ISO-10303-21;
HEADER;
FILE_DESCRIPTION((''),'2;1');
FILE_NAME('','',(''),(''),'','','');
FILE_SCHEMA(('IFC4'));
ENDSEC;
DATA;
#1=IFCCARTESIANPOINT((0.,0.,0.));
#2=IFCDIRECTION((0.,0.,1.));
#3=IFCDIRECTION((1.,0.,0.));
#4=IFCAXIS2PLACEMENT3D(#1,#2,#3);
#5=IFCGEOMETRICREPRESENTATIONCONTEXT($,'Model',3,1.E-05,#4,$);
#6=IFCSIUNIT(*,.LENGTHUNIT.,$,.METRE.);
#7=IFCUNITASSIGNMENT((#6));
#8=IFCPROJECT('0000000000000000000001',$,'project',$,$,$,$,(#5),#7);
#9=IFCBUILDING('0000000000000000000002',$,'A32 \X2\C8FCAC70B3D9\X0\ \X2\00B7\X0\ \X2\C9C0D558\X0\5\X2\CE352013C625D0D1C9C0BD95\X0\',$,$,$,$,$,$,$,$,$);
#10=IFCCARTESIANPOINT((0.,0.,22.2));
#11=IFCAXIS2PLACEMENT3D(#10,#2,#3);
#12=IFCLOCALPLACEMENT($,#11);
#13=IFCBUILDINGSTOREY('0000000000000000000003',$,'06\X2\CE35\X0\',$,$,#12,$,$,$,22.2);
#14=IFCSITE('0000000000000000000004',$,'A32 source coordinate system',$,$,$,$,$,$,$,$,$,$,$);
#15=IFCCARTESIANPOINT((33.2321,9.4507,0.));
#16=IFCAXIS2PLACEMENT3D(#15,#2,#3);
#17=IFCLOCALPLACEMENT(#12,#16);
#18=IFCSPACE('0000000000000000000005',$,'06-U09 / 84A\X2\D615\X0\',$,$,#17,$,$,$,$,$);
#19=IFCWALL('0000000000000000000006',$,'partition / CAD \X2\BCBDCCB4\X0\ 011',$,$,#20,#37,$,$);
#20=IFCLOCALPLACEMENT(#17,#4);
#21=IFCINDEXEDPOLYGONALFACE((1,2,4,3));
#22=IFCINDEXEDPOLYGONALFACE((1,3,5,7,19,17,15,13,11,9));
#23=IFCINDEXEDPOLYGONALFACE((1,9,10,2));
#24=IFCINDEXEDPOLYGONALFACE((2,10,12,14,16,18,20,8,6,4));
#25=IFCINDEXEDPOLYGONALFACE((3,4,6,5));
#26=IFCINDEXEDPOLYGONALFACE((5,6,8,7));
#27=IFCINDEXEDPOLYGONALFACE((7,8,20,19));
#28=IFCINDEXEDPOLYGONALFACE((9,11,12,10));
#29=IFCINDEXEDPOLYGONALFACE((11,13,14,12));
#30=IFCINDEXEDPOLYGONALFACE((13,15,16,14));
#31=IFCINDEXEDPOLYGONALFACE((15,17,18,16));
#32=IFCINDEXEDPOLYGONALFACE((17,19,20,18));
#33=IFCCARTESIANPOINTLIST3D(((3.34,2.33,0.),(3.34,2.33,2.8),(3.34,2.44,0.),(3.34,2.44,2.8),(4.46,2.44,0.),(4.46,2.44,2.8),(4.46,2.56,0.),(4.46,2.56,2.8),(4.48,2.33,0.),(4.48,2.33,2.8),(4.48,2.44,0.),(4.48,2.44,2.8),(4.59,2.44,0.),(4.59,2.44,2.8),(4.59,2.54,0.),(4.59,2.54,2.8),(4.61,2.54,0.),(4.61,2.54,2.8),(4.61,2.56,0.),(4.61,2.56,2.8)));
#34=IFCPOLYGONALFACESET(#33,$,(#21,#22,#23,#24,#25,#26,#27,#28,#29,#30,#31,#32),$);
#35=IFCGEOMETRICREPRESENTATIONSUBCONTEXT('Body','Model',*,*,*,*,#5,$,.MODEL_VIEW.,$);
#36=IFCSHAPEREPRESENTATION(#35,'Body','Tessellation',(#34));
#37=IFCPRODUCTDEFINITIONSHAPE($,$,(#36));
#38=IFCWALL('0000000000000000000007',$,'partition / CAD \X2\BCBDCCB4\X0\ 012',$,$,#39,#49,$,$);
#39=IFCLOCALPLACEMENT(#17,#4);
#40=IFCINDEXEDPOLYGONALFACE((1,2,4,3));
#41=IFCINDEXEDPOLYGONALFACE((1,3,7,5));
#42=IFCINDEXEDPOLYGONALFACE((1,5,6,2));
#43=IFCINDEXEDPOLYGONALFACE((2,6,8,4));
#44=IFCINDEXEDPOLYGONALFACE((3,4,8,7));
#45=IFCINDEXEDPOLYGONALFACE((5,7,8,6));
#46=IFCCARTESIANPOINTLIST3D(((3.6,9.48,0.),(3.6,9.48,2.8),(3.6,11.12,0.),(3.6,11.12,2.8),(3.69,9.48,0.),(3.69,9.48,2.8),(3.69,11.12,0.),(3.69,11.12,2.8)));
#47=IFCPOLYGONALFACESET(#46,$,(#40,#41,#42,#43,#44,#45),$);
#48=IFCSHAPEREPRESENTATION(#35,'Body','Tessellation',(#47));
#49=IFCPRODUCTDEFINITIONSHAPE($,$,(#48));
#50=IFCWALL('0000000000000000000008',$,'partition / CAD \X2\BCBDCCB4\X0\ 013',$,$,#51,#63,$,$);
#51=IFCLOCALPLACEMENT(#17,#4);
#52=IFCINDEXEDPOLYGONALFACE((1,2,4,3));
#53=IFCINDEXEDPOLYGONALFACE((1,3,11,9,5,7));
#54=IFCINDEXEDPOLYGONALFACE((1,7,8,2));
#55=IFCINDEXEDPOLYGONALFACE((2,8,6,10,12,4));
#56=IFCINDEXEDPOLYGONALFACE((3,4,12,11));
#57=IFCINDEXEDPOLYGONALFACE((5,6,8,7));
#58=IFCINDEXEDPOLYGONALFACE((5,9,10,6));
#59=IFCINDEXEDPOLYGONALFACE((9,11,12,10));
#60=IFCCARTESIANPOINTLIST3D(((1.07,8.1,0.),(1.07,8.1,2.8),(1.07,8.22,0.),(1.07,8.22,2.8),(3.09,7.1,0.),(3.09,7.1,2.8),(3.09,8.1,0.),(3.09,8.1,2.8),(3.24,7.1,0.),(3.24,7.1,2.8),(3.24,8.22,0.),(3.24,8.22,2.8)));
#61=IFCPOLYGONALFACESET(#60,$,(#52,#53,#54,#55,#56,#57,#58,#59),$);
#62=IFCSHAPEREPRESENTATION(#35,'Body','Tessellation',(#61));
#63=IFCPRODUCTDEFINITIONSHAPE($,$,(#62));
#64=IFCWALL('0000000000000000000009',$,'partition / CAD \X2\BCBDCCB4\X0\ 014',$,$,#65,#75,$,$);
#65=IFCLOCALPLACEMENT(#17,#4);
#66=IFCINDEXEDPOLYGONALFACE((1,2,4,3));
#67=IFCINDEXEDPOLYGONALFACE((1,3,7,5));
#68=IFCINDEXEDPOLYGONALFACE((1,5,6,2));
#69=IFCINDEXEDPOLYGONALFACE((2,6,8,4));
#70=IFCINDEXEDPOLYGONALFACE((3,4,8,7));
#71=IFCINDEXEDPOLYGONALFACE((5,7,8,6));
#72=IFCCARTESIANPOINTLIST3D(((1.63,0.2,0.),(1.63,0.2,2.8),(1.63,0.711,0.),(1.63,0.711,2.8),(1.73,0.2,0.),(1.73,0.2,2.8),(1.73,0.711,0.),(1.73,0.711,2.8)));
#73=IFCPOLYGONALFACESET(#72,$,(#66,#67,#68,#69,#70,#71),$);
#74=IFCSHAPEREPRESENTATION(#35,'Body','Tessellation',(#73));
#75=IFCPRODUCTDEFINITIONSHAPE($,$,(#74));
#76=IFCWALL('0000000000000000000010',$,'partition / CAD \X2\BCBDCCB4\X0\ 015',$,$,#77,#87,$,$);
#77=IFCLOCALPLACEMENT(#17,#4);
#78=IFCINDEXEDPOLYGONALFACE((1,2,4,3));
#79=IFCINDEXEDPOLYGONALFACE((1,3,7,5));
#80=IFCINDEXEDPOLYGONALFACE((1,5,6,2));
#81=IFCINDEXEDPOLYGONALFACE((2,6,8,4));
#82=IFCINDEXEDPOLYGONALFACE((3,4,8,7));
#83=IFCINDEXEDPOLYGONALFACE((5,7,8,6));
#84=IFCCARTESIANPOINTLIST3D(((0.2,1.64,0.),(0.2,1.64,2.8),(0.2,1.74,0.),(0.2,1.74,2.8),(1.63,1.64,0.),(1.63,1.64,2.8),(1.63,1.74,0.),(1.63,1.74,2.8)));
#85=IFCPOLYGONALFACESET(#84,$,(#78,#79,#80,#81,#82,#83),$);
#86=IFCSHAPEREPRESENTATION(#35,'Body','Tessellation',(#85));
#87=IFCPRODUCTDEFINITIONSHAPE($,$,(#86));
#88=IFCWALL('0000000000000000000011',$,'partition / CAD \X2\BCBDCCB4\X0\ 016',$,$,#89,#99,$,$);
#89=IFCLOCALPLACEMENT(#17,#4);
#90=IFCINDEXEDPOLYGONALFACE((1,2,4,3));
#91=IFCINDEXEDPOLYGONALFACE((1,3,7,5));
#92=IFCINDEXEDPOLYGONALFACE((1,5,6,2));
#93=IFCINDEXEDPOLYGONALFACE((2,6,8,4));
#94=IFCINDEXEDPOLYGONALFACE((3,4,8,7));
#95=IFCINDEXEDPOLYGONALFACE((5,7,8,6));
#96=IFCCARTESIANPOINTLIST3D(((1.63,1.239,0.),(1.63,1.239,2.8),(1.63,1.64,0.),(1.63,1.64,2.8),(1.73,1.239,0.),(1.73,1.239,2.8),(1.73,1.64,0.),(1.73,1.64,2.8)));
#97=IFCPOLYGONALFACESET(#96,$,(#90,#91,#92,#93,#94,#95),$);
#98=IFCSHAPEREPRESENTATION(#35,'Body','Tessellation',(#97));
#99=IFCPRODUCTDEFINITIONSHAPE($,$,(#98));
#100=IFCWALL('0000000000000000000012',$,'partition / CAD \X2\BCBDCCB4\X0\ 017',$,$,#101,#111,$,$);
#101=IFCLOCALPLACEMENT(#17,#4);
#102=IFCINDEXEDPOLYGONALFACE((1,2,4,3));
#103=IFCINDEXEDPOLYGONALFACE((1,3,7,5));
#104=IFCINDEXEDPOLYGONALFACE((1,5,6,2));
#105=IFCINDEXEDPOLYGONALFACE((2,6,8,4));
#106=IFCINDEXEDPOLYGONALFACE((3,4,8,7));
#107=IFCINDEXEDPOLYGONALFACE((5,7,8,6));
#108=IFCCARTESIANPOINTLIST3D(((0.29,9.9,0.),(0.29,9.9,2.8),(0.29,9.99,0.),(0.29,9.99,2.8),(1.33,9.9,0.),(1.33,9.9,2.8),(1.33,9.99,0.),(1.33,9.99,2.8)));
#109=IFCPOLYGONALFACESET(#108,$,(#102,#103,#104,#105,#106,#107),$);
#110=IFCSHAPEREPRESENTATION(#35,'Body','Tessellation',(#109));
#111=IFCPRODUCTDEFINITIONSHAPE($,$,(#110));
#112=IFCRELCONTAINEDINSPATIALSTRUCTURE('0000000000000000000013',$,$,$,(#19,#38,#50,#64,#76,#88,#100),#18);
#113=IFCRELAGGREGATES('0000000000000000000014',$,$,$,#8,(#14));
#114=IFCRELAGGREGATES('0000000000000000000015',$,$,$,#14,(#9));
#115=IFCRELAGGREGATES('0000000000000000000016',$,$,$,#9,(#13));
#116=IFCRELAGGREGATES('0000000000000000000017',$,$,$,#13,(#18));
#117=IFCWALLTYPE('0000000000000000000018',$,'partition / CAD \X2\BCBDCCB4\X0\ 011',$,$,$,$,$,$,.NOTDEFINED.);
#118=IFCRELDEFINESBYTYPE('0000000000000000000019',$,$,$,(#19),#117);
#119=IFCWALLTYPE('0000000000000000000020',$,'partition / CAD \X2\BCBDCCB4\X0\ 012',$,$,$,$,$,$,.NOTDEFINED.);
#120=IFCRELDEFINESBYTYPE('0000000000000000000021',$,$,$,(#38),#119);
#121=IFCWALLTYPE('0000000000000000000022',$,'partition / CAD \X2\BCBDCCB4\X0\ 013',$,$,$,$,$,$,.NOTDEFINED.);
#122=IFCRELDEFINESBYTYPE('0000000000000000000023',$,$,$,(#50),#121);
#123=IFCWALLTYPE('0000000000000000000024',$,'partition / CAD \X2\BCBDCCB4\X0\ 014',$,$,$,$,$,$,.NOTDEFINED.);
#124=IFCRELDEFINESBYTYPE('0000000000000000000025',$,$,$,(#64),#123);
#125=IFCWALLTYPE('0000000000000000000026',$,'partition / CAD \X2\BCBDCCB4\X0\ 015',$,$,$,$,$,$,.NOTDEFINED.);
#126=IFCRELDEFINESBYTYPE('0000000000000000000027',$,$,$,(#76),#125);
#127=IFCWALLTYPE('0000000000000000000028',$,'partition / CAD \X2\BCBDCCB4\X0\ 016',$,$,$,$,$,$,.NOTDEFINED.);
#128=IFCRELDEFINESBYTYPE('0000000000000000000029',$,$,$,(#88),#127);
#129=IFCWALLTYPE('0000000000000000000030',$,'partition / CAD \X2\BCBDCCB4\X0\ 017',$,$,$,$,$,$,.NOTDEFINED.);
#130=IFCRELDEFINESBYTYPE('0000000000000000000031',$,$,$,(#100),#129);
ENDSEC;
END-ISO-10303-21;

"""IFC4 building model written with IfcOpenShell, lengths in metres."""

from ifc_helpers import new_model, si_unit, frame, origin, origin_with_axes, place, context, subcontext, project, spatial, polyline, outline, extrude, source, transform, mapped, type_object, type_shapes, element, save


model = new_model("IFC4")

# Units and contexts
model_context = context("Model", 3, precision=1e-05, world=origin_with_axes())
body_context = subcontext(model_context, "Body", "Model", "MODEL_VIEW")
ifc_project = project(units=[si_unit("LENGTHUNIT", "METRE")], contexts=[model_context])

# Site, building, storey, space
storey_placement = place(None, frame((0.0, 0.0, 22.2), z_axis=(0.0, 0.0, 1.0), x_axis=(1.0, 0.0, 0.0)))
space_placement = place(storey_placement, frame((33.2321, 9.4507, 0.0), z_axis=(0.0, 0.0, 1.0), x_axis=(1.0, 0.0, 0.0)))
site = spatial("IfcSite", under=ifc_project, Name="A32 source coordinate system")
building = spatial("IfcBuilding", under=site, Name="A32 주거동 · 지하5층–옥탑지붕")
storey = spatial("IfcBuildingStorey", under=building, at=storey_placement, Name="06층", Elevation=22.2)
space = spatial("IfcSpace", under=storey, at=space_placement, Name="06-U09 / 84A형")

# Walls
wall_type_1 = type_object("IfcWallType", Name="partition / CAD 벽체 011", PredefinedType="NOTDEFINED")
shared_shape_1 = source(origin(), body_context, "Body", "SweptSolid", [
    extrude(outline(polyline([(3.34, 2.33), (3.34, 2.44), (4.46, 2.44), (4.46, 2.56), (4.61, 2.56), (4.61, 2.54), (4.59, 2.54), (4.59, 2.44), (4.48, 2.44), (4.48, 2.33), (3.34, 2.33)])), origin(), (0.0, 0.0, 1.0), 2.8),
])
type_shapes(wall_type_1, [shared_shape_1])
wall_1_placement = place(space_placement, origin_with_axes())
element("IfcWall", 1, at=wall_1_placement, inside=space, type_object=wall_type_1, Name="partition / CAD 벽체 011", context=body_context, shape_type="MappedRepresentation", body=[
    mapped(shared_shape_1, transform((0.0, 0.0, 0.0), scale=1.0)),
])
wall_type_2 = type_object("IfcWallType", Name="partition / CAD 벽체 012", PredefinedType="NOTDEFINED")
shared_shape_2 = source(origin(), body_context, "Body", "SweptSolid", [
    extrude(outline(polyline([(3.6, 11.12), (3.69, 11.12), (3.69, 9.48), (3.6, 9.48), (3.6, 11.12)])), origin(), (0.0, 0.0, 1.0), 2.8),
])
type_shapes(wall_type_2, [shared_shape_2])
wall_2_placement = place(space_placement, origin_with_axes())
element("IfcWall", 2, at=wall_2_placement, inside=space, type_object=wall_type_2, Name="partition / CAD 벽체 012", context=body_context, shape_type="MappedRepresentation", body=[
    mapped(shared_shape_2, transform((0.0, 0.0, 0.0), scale=1.0)),
])
wall_type_3 = type_object("IfcWallType", Name="partition / CAD 벽체 013", PredefinedType="NOTDEFINED")
shared_shape_3 = source(origin(), body_context, "Body", "SweptSolid", [
    extrude(outline(polyline([(3.09, 8.1), (1.07, 8.1), (1.07, 8.22), (3.24, 8.22), (3.24, 7.1), (3.09, 7.1), (3.09, 8.1)])), origin(), (0.0, 0.0, 1.0), 2.8),
])
type_shapes(wall_type_3, [shared_shape_3])
wall_3_placement = place(space_placement, origin_with_axes())
element("IfcWall", 3, at=wall_3_placement, inside=space, type_object=wall_type_3, Name="partition / CAD 벽체 013", context=body_context, shape_type="MappedRepresentation", body=[
    mapped(shared_shape_3, transform((0.0, 0.0, 0.0), scale=1.0)),
])
wall_type_4 = type_object("IfcWallType", Name="partition / CAD 벽체 014", PredefinedType="NOTDEFINED")
shared_shape_4 = source(origin(), body_context, "Body", "SweptSolid", [
    extrude(outline(polyline([(1.73, 0.2), (1.63, 0.2), (1.63, 0.711), (1.73, 0.711), (1.73, 0.2)])), origin(), (0.0, 0.0, 1.0), 2.8),
])
type_shapes(wall_type_4, [shared_shape_4])
wall_4_placement = place(space_placement, origin_with_axes())
element("IfcWall", 4, at=wall_4_placement, inside=space, type_object=wall_type_4, Name="partition / CAD 벽체 014", context=body_context, shape_type="MappedRepresentation", body=[
    mapped(shared_shape_4, transform((0.0, 0.0, 0.0), scale=1.0)),
])
wall_type_5 = type_object("IfcWallType", Name="partition / CAD 벽체 015", PredefinedType="NOTDEFINED")
shared_shape_5 = source(origin(), body_context, "Body", "SweptSolid", [
    extrude(outline(polyline([(1.63, 1.74), (1.63, 1.64), (0.2, 1.64), (0.2, 1.74), (1.63, 1.74)])), origin(), (0.0, 0.0, 1.0), 2.8),
])
type_shapes(wall_type_5, [shared_shape_5])
wall_5_placement = place(space_placement, origin_with_axes())
element("IfcWall", 5, at=wall_5_placement, inside=space, type_object=wall_type_5, Name="partition / CAD 벽체 015", context=body_context, shape_type="MappedRepresentation", body=[
    mapped(shared_shape_5, transform((0.0, 0.0, 0.0), scale=1.0)),
])
wall_type_6 = type_object("IfcWallType", Name="partition / CAD 벽체 016", PredefinedType="NOTDEFINED")
shared_shape_6 = source(origin(), body_context, "Body", "SweptSolid", [
    extrude(outline(polyline([(1.73, 1.239), (1.63, 1.239), (1.63, 1.64), (1.73, 1.64), (1.73, 1.239)])), origin(), (0.0, 0.0, 1.0), 2.8),
])
type_shapes(wall_type_6, [shared_shape_6])
wall_6_placement = place(space_placement, origin_with_axes())
element("IfcWall", 6, at=wall_6_placement, inside=space, type_object=wall_type_6, Name="partition / CAD 벽체 016", context=body_context, shape_type="MappedRepresentation", body=[
    mapped(shared_shape_6, transform((0.0, 0.0, 0.0), scale=1.0)),
])
wall_type_7 = type_object("IfcWallType", Name="partition / CAD 벽체 017", PredefinedType="NOTDEFINED")
shared_shape_7 = source(origin(), body_context, "Body", "SweptSolid", [
    extrude(outline(polyline([(1.33, 9.99), (1.33, 9.9), (0.29, 9.9), (0.29, 9.99), (1.33, 9.99)])), origin(), (0.0, 0.0, 1.0), 2.8),
])
type_shapes(wall_type_7, [shared_shape_7])
wall_7_placement = place(space_placement, origin_with_axes())
element("IfcWall", 7, at=wall_7_placement, inside=space, type_object=wall_type_7, Name="partition / CAD 벽체 017", context=body_context, shape_type="MappedRepresentation", body=[
    mapped(shared_shape_7, transform((0.0, 0.0, 0.0), scale=1.0)),
])

save(model, "model.ifc")
